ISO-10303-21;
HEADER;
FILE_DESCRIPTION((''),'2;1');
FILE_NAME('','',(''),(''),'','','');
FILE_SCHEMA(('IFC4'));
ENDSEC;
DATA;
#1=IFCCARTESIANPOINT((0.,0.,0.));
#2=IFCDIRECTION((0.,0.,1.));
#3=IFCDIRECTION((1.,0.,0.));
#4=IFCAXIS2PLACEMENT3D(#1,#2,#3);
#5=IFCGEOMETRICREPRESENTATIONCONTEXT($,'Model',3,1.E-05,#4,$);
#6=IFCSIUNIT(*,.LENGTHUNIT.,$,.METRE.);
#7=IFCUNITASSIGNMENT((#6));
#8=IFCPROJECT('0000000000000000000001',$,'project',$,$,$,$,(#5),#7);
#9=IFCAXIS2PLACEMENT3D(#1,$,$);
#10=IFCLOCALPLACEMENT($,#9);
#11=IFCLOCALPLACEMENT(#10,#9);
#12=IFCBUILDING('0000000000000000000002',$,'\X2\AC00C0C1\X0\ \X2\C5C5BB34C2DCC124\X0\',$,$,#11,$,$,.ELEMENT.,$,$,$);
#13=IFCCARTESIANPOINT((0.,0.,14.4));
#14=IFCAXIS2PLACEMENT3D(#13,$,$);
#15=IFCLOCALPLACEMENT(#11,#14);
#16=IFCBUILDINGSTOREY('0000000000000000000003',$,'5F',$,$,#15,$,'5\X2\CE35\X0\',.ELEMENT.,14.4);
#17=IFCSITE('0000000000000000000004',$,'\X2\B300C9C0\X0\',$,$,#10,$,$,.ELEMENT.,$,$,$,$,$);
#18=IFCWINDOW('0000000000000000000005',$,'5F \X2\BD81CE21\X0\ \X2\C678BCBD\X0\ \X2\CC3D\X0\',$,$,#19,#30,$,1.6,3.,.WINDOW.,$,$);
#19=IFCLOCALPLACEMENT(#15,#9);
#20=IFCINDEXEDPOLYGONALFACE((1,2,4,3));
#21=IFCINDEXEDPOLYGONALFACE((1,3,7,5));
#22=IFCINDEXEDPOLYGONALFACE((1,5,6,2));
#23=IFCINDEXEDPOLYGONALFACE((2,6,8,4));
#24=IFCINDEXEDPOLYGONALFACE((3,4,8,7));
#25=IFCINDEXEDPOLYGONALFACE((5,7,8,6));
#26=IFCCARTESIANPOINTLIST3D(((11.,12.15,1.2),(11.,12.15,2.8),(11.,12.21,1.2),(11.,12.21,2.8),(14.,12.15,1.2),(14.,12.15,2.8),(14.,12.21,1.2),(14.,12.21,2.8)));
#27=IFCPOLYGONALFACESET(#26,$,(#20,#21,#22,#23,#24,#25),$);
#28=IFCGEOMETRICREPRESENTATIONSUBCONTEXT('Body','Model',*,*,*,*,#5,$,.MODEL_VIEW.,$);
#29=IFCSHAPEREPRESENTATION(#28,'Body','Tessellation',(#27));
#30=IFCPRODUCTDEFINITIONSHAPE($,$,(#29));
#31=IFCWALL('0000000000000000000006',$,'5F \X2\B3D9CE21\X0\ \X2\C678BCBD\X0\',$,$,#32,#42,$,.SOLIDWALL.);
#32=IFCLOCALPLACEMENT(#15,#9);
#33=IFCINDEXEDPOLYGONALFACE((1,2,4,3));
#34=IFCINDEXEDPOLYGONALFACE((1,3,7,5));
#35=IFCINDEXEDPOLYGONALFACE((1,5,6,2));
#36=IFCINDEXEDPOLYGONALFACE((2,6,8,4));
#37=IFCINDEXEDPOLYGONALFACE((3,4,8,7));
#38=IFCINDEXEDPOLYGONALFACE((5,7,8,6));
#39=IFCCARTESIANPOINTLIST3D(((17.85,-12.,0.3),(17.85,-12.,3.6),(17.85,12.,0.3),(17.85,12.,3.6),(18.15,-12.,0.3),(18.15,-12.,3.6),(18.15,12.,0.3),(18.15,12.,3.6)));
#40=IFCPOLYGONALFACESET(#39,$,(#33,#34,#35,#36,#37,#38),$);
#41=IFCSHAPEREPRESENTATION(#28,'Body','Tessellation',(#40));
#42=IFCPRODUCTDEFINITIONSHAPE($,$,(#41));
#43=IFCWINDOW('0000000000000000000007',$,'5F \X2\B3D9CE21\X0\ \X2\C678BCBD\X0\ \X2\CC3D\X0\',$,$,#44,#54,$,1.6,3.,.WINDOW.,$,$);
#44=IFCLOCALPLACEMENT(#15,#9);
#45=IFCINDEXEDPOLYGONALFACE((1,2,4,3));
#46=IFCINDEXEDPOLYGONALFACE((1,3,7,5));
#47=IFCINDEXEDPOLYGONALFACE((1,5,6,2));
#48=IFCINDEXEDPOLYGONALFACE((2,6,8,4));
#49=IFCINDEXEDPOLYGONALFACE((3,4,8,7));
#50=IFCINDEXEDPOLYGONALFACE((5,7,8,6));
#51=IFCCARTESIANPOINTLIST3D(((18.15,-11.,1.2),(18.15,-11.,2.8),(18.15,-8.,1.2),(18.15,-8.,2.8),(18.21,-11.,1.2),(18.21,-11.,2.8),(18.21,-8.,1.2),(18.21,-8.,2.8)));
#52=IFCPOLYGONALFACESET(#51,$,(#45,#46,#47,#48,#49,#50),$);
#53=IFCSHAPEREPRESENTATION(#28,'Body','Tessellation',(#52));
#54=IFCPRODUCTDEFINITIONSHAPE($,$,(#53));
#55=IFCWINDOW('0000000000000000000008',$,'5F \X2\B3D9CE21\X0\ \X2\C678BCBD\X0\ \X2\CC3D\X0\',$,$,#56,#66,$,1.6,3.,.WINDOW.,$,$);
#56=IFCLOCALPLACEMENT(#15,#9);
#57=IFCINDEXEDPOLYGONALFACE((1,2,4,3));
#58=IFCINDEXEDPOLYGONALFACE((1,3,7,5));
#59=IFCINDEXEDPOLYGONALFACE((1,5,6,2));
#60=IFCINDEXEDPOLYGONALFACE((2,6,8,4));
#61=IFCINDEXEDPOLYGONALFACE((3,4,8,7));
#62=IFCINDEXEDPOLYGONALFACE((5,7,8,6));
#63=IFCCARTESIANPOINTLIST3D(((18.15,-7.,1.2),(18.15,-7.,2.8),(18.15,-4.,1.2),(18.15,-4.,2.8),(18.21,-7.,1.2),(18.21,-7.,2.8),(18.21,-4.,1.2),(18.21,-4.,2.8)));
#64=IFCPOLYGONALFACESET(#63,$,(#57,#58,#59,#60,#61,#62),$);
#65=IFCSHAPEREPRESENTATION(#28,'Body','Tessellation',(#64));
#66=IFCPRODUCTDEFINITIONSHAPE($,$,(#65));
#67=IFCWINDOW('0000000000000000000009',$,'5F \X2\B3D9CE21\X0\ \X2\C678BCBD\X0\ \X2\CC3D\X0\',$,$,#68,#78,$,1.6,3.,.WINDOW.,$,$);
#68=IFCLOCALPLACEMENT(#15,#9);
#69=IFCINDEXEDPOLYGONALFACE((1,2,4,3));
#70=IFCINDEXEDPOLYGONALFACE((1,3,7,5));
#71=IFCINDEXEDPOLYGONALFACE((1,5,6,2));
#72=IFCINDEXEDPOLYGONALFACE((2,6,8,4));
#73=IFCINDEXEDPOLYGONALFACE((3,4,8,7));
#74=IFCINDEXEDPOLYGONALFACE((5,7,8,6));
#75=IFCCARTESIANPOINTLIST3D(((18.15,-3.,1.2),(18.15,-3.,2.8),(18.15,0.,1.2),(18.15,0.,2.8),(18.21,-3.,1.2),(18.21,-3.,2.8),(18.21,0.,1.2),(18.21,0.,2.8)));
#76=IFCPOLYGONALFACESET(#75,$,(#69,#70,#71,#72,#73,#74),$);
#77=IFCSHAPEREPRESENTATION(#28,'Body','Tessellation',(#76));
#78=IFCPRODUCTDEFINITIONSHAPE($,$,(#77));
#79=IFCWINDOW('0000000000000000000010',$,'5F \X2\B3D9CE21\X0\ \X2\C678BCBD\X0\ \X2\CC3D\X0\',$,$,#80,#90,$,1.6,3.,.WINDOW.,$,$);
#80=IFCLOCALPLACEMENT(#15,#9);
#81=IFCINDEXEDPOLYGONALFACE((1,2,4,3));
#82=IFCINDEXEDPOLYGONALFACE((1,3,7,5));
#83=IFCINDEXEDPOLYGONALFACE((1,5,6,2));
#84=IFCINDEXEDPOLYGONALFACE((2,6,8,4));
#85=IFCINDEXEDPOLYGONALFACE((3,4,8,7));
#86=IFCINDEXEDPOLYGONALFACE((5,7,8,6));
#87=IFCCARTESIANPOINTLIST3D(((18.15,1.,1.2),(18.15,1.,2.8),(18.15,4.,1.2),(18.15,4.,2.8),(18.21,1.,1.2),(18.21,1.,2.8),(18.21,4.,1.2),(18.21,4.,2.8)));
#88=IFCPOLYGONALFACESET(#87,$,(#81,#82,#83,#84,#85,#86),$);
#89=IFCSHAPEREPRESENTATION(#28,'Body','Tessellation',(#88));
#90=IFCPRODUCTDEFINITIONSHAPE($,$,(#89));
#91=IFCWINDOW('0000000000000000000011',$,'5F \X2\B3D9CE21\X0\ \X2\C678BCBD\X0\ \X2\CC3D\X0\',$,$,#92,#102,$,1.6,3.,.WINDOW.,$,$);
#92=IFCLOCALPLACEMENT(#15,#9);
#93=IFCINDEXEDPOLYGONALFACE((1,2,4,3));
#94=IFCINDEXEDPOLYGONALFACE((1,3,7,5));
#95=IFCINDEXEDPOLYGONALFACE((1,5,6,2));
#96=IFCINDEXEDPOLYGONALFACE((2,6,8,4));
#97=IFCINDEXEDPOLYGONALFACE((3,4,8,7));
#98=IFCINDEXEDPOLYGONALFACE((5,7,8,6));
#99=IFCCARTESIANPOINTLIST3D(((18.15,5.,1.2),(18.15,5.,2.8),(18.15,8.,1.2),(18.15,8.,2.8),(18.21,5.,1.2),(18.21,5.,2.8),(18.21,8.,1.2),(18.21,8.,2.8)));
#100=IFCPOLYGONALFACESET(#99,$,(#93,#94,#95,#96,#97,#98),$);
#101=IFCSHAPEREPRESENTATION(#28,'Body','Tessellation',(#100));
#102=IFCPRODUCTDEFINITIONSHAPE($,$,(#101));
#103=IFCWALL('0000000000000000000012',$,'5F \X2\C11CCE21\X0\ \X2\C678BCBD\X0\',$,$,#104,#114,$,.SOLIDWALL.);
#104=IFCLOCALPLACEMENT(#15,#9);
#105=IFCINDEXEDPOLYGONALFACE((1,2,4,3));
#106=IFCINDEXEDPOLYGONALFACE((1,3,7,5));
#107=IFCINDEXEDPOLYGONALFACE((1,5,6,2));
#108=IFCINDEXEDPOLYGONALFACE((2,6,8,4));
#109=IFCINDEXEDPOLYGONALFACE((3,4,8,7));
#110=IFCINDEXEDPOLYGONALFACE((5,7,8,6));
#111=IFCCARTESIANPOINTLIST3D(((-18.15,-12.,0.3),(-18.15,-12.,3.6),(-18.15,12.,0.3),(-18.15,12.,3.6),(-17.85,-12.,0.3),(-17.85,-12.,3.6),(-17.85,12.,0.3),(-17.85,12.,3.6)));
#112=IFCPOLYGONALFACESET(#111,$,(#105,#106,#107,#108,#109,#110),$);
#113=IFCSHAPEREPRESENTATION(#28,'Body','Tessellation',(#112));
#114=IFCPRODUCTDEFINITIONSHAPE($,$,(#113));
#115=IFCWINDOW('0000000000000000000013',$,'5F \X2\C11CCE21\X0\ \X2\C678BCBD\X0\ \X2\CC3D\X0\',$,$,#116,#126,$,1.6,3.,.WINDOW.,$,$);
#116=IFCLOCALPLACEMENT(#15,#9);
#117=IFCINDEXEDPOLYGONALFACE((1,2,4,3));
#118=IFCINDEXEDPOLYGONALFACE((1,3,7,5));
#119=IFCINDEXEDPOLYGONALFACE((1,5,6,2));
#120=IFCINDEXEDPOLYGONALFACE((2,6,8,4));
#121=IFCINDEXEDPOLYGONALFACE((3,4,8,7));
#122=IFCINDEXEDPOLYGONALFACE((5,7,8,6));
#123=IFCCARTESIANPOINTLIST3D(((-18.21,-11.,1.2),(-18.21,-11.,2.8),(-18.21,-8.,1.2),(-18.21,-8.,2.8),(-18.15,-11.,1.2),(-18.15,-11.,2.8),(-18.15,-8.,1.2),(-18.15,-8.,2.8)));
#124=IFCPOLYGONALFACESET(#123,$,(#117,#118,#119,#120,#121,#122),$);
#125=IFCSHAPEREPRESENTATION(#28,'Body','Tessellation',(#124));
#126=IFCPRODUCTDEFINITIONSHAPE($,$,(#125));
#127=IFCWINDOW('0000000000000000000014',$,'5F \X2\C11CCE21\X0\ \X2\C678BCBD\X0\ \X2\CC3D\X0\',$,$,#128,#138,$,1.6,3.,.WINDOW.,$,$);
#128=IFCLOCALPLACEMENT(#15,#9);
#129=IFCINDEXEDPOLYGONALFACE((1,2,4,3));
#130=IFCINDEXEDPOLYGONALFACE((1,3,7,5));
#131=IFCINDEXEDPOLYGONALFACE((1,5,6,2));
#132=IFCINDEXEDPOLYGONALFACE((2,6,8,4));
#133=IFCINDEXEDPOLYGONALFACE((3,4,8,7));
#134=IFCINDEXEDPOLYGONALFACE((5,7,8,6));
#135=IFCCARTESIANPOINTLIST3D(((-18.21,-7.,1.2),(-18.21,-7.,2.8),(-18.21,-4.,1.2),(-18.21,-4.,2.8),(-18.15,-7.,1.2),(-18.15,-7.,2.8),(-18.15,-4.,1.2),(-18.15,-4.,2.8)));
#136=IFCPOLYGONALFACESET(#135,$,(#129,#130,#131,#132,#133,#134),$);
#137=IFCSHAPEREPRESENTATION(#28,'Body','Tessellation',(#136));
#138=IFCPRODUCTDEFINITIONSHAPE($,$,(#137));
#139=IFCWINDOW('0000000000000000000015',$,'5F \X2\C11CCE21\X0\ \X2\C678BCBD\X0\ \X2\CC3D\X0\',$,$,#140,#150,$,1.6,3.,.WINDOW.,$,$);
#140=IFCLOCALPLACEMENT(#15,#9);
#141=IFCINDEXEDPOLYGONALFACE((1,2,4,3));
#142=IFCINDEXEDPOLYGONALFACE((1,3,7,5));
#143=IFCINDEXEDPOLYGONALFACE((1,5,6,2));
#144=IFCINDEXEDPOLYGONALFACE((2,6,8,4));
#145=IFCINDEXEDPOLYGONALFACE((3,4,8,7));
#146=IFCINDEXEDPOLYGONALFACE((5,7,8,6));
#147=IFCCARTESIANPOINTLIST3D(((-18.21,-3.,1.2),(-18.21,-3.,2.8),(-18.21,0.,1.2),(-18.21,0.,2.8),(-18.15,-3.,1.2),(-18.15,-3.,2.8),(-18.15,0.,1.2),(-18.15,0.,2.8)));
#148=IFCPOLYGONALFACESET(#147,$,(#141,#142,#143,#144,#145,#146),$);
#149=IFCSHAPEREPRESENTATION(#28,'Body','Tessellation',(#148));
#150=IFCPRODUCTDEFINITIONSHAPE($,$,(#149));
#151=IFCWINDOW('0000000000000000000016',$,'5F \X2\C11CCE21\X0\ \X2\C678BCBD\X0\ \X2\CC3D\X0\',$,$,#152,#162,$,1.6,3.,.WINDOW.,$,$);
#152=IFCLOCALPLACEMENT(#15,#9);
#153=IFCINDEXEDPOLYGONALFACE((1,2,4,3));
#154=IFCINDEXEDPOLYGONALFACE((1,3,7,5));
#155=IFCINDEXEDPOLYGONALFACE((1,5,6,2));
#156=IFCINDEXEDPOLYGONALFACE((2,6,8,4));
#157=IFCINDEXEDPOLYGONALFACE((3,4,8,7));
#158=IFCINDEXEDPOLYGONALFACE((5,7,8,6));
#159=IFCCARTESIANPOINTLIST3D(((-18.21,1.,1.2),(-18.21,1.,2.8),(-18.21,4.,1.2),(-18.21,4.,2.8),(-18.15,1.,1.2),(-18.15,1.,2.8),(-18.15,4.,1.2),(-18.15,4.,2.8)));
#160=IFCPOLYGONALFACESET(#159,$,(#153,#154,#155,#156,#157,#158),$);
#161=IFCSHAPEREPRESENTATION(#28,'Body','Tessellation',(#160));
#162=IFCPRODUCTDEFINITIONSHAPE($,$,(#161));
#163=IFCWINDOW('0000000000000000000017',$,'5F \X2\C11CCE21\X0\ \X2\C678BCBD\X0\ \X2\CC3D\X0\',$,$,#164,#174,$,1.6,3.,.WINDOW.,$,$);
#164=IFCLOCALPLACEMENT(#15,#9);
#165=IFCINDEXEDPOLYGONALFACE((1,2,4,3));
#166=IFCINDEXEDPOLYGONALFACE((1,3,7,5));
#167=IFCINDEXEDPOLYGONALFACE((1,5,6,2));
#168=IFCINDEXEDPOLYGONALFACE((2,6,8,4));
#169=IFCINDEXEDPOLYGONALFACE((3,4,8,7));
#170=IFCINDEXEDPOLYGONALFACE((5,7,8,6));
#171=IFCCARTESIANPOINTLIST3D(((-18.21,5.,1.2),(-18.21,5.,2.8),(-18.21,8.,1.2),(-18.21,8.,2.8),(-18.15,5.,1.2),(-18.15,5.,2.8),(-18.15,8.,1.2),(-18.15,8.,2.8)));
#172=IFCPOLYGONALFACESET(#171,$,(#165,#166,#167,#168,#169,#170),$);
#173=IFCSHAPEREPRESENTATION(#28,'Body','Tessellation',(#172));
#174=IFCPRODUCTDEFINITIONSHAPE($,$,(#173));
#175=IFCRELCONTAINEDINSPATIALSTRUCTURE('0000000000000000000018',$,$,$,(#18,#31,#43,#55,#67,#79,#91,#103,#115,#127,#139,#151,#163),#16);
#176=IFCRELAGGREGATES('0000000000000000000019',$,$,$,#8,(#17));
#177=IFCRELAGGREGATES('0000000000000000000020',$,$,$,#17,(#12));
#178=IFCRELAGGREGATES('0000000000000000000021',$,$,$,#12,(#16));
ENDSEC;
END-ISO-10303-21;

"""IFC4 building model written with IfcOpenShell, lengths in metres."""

from ifc_helpers import new_model, si_unit, frame, origin, origin_with_axes, origin_2d, place, context, subcontext, project, spatial, rectangle, extrude, element, save


model = new_model("IFC4")

# Units and contexts
model_context = context("Model", 3, precision=1e-05, world=origin_with_axes())
body_context = subcontext(model_context, "Body", "Model", "MODEL_VIEW")
ifc_project = project(units=[si_unit("LENGTHUNIT", "METRE")], contexts=[model_context])

# Site, building, storey
site_placement = place(None, origin())
site = spatial("IfcSite", under=ifc_project, at=site_placement, Name="대지", CompositionType="ELEMENT")
building_placement = place(site_placement, origin())
building = spatial("IfcBuilding", under=site, at=building_placement, Name="가상 업무시설", CompositionType="ELEMENT")
storey_placement = place(building_placement, frame((0.0, 0.0, 14.4)))
storey = spatial("IfcBuildingStorey", under=building, at=storey_placement, Name="5F", LongName="5층", CompositionType="ELEMENT", Elevation=14.4)

# Window
for number, where, name in (
    (1, (12.5, 12.18, 1.2), "5F 북측 외벽 창"),
):
    element("IfcWindow", number, at=place(storey_placement, frame(where)), inside=storey, Name=name, OverallHeight=1.6, OverallWidth=3.0, PredefinedType="WINDOW", context=body_context, shape_type="SweptSolid", body=[
        extrude(rectangle(XDim=3.0, YDim=0.06, at=origin_2d()), origin_with_axes(), (0.0, 0.0, 1.0), 1.6),
    ])

# Wall
wall_1_placement = place(storey_placement, frame((18.0, 0.0, 0.3)))
element("IfcWall", 2, at=wall_1_placement, inside=storey, Name="5F 동측 외벽", PredefinedType="SOLIDWALL", context=body_context, shape_type="SweptSolid", body=[
    extrude(rectangle(XDim=0.3, YDim=24.0, at=origin_2d()), origin_with_axes(), (0.0, 0.0, 1.0), 3.3),
])

# Windows
for number, where, name in (
    (3, (18.18, -9.5, 1.2), "5F 동측 외벽 창"),
    (4, (18.18, -5.5, 1.2), "5F 동측 외벽 창"),
    (5, (18.18, -1.5, 1.2), "5F 동측 외벽 창"),
    (6, (18.18, 2.5, 1.2), "5F 동측 외벽 창"),
    (7, (18.18, 6.5, 1.2), "5F 동측 외벽 창"),
):
    element("IfcWindow", number, at=place(storey_placement, frame(where)), inside=storey, Name=name, OverallHeight=1.6, OverallWidth=3.0, PredefinedType="WINDOW", context=body_context, shape_type="SweptSolid", body=[
        extrude(rectangle(XDim=0.06, YDim=3.0, at=origin_2d()), origin_with_axes(), (0.0, 0.0, 1.0), 1.6),
    ])

# Wall
wall_2_placement = place(storey_placement, frame((-18.0, 0.0, 0.3)))
element("IfcWall", 8, at=wall_2_placement, inside=storey, Name="5F 서측 외벽", PredefinedType="SOLIDWALL", context=body_context, shape_type="SweptSolid", body=[
    extrude(rectangle(XDim=0.3, YDim=24.0, at=origin_2d()), origin_with_axes(), (0.0, 0.0, 1.0), 3.3),
])

# Windows
for number, where, name in (
    (9, (-18.18, -9.5, 1.2), "5F 서측 외벽 창"),
    (10, (-18.18, -5.5, 1.2), "5F 서측 외벽 창"),
    (11, (-18.18, -1.5, 1.2), "5F 서측 외벽 창"),
    (12, (-18.18, 2.5, 1.2), "5F 서측 외벽 창"),
    (13, (-18.18, 6.5, 1.2), "5F 서측 외벽 창"),
):
    element("IfcWindow", number, at=place(storey_placement, frame(where)), inside=storey, Name=name, OverallHeight=1.6, OverallWidth=3.0, PredefinedType="WINDOW", context=body_context, shape_type="SweptSolid", body=[
        extrude(rectangle(XDim=0.06, YDim=3.0, at=origin_2d()), origin_with_axes(), (0.0, 0.0, 1.0), 1.6),
    ])

save(model, "model.ifc")
